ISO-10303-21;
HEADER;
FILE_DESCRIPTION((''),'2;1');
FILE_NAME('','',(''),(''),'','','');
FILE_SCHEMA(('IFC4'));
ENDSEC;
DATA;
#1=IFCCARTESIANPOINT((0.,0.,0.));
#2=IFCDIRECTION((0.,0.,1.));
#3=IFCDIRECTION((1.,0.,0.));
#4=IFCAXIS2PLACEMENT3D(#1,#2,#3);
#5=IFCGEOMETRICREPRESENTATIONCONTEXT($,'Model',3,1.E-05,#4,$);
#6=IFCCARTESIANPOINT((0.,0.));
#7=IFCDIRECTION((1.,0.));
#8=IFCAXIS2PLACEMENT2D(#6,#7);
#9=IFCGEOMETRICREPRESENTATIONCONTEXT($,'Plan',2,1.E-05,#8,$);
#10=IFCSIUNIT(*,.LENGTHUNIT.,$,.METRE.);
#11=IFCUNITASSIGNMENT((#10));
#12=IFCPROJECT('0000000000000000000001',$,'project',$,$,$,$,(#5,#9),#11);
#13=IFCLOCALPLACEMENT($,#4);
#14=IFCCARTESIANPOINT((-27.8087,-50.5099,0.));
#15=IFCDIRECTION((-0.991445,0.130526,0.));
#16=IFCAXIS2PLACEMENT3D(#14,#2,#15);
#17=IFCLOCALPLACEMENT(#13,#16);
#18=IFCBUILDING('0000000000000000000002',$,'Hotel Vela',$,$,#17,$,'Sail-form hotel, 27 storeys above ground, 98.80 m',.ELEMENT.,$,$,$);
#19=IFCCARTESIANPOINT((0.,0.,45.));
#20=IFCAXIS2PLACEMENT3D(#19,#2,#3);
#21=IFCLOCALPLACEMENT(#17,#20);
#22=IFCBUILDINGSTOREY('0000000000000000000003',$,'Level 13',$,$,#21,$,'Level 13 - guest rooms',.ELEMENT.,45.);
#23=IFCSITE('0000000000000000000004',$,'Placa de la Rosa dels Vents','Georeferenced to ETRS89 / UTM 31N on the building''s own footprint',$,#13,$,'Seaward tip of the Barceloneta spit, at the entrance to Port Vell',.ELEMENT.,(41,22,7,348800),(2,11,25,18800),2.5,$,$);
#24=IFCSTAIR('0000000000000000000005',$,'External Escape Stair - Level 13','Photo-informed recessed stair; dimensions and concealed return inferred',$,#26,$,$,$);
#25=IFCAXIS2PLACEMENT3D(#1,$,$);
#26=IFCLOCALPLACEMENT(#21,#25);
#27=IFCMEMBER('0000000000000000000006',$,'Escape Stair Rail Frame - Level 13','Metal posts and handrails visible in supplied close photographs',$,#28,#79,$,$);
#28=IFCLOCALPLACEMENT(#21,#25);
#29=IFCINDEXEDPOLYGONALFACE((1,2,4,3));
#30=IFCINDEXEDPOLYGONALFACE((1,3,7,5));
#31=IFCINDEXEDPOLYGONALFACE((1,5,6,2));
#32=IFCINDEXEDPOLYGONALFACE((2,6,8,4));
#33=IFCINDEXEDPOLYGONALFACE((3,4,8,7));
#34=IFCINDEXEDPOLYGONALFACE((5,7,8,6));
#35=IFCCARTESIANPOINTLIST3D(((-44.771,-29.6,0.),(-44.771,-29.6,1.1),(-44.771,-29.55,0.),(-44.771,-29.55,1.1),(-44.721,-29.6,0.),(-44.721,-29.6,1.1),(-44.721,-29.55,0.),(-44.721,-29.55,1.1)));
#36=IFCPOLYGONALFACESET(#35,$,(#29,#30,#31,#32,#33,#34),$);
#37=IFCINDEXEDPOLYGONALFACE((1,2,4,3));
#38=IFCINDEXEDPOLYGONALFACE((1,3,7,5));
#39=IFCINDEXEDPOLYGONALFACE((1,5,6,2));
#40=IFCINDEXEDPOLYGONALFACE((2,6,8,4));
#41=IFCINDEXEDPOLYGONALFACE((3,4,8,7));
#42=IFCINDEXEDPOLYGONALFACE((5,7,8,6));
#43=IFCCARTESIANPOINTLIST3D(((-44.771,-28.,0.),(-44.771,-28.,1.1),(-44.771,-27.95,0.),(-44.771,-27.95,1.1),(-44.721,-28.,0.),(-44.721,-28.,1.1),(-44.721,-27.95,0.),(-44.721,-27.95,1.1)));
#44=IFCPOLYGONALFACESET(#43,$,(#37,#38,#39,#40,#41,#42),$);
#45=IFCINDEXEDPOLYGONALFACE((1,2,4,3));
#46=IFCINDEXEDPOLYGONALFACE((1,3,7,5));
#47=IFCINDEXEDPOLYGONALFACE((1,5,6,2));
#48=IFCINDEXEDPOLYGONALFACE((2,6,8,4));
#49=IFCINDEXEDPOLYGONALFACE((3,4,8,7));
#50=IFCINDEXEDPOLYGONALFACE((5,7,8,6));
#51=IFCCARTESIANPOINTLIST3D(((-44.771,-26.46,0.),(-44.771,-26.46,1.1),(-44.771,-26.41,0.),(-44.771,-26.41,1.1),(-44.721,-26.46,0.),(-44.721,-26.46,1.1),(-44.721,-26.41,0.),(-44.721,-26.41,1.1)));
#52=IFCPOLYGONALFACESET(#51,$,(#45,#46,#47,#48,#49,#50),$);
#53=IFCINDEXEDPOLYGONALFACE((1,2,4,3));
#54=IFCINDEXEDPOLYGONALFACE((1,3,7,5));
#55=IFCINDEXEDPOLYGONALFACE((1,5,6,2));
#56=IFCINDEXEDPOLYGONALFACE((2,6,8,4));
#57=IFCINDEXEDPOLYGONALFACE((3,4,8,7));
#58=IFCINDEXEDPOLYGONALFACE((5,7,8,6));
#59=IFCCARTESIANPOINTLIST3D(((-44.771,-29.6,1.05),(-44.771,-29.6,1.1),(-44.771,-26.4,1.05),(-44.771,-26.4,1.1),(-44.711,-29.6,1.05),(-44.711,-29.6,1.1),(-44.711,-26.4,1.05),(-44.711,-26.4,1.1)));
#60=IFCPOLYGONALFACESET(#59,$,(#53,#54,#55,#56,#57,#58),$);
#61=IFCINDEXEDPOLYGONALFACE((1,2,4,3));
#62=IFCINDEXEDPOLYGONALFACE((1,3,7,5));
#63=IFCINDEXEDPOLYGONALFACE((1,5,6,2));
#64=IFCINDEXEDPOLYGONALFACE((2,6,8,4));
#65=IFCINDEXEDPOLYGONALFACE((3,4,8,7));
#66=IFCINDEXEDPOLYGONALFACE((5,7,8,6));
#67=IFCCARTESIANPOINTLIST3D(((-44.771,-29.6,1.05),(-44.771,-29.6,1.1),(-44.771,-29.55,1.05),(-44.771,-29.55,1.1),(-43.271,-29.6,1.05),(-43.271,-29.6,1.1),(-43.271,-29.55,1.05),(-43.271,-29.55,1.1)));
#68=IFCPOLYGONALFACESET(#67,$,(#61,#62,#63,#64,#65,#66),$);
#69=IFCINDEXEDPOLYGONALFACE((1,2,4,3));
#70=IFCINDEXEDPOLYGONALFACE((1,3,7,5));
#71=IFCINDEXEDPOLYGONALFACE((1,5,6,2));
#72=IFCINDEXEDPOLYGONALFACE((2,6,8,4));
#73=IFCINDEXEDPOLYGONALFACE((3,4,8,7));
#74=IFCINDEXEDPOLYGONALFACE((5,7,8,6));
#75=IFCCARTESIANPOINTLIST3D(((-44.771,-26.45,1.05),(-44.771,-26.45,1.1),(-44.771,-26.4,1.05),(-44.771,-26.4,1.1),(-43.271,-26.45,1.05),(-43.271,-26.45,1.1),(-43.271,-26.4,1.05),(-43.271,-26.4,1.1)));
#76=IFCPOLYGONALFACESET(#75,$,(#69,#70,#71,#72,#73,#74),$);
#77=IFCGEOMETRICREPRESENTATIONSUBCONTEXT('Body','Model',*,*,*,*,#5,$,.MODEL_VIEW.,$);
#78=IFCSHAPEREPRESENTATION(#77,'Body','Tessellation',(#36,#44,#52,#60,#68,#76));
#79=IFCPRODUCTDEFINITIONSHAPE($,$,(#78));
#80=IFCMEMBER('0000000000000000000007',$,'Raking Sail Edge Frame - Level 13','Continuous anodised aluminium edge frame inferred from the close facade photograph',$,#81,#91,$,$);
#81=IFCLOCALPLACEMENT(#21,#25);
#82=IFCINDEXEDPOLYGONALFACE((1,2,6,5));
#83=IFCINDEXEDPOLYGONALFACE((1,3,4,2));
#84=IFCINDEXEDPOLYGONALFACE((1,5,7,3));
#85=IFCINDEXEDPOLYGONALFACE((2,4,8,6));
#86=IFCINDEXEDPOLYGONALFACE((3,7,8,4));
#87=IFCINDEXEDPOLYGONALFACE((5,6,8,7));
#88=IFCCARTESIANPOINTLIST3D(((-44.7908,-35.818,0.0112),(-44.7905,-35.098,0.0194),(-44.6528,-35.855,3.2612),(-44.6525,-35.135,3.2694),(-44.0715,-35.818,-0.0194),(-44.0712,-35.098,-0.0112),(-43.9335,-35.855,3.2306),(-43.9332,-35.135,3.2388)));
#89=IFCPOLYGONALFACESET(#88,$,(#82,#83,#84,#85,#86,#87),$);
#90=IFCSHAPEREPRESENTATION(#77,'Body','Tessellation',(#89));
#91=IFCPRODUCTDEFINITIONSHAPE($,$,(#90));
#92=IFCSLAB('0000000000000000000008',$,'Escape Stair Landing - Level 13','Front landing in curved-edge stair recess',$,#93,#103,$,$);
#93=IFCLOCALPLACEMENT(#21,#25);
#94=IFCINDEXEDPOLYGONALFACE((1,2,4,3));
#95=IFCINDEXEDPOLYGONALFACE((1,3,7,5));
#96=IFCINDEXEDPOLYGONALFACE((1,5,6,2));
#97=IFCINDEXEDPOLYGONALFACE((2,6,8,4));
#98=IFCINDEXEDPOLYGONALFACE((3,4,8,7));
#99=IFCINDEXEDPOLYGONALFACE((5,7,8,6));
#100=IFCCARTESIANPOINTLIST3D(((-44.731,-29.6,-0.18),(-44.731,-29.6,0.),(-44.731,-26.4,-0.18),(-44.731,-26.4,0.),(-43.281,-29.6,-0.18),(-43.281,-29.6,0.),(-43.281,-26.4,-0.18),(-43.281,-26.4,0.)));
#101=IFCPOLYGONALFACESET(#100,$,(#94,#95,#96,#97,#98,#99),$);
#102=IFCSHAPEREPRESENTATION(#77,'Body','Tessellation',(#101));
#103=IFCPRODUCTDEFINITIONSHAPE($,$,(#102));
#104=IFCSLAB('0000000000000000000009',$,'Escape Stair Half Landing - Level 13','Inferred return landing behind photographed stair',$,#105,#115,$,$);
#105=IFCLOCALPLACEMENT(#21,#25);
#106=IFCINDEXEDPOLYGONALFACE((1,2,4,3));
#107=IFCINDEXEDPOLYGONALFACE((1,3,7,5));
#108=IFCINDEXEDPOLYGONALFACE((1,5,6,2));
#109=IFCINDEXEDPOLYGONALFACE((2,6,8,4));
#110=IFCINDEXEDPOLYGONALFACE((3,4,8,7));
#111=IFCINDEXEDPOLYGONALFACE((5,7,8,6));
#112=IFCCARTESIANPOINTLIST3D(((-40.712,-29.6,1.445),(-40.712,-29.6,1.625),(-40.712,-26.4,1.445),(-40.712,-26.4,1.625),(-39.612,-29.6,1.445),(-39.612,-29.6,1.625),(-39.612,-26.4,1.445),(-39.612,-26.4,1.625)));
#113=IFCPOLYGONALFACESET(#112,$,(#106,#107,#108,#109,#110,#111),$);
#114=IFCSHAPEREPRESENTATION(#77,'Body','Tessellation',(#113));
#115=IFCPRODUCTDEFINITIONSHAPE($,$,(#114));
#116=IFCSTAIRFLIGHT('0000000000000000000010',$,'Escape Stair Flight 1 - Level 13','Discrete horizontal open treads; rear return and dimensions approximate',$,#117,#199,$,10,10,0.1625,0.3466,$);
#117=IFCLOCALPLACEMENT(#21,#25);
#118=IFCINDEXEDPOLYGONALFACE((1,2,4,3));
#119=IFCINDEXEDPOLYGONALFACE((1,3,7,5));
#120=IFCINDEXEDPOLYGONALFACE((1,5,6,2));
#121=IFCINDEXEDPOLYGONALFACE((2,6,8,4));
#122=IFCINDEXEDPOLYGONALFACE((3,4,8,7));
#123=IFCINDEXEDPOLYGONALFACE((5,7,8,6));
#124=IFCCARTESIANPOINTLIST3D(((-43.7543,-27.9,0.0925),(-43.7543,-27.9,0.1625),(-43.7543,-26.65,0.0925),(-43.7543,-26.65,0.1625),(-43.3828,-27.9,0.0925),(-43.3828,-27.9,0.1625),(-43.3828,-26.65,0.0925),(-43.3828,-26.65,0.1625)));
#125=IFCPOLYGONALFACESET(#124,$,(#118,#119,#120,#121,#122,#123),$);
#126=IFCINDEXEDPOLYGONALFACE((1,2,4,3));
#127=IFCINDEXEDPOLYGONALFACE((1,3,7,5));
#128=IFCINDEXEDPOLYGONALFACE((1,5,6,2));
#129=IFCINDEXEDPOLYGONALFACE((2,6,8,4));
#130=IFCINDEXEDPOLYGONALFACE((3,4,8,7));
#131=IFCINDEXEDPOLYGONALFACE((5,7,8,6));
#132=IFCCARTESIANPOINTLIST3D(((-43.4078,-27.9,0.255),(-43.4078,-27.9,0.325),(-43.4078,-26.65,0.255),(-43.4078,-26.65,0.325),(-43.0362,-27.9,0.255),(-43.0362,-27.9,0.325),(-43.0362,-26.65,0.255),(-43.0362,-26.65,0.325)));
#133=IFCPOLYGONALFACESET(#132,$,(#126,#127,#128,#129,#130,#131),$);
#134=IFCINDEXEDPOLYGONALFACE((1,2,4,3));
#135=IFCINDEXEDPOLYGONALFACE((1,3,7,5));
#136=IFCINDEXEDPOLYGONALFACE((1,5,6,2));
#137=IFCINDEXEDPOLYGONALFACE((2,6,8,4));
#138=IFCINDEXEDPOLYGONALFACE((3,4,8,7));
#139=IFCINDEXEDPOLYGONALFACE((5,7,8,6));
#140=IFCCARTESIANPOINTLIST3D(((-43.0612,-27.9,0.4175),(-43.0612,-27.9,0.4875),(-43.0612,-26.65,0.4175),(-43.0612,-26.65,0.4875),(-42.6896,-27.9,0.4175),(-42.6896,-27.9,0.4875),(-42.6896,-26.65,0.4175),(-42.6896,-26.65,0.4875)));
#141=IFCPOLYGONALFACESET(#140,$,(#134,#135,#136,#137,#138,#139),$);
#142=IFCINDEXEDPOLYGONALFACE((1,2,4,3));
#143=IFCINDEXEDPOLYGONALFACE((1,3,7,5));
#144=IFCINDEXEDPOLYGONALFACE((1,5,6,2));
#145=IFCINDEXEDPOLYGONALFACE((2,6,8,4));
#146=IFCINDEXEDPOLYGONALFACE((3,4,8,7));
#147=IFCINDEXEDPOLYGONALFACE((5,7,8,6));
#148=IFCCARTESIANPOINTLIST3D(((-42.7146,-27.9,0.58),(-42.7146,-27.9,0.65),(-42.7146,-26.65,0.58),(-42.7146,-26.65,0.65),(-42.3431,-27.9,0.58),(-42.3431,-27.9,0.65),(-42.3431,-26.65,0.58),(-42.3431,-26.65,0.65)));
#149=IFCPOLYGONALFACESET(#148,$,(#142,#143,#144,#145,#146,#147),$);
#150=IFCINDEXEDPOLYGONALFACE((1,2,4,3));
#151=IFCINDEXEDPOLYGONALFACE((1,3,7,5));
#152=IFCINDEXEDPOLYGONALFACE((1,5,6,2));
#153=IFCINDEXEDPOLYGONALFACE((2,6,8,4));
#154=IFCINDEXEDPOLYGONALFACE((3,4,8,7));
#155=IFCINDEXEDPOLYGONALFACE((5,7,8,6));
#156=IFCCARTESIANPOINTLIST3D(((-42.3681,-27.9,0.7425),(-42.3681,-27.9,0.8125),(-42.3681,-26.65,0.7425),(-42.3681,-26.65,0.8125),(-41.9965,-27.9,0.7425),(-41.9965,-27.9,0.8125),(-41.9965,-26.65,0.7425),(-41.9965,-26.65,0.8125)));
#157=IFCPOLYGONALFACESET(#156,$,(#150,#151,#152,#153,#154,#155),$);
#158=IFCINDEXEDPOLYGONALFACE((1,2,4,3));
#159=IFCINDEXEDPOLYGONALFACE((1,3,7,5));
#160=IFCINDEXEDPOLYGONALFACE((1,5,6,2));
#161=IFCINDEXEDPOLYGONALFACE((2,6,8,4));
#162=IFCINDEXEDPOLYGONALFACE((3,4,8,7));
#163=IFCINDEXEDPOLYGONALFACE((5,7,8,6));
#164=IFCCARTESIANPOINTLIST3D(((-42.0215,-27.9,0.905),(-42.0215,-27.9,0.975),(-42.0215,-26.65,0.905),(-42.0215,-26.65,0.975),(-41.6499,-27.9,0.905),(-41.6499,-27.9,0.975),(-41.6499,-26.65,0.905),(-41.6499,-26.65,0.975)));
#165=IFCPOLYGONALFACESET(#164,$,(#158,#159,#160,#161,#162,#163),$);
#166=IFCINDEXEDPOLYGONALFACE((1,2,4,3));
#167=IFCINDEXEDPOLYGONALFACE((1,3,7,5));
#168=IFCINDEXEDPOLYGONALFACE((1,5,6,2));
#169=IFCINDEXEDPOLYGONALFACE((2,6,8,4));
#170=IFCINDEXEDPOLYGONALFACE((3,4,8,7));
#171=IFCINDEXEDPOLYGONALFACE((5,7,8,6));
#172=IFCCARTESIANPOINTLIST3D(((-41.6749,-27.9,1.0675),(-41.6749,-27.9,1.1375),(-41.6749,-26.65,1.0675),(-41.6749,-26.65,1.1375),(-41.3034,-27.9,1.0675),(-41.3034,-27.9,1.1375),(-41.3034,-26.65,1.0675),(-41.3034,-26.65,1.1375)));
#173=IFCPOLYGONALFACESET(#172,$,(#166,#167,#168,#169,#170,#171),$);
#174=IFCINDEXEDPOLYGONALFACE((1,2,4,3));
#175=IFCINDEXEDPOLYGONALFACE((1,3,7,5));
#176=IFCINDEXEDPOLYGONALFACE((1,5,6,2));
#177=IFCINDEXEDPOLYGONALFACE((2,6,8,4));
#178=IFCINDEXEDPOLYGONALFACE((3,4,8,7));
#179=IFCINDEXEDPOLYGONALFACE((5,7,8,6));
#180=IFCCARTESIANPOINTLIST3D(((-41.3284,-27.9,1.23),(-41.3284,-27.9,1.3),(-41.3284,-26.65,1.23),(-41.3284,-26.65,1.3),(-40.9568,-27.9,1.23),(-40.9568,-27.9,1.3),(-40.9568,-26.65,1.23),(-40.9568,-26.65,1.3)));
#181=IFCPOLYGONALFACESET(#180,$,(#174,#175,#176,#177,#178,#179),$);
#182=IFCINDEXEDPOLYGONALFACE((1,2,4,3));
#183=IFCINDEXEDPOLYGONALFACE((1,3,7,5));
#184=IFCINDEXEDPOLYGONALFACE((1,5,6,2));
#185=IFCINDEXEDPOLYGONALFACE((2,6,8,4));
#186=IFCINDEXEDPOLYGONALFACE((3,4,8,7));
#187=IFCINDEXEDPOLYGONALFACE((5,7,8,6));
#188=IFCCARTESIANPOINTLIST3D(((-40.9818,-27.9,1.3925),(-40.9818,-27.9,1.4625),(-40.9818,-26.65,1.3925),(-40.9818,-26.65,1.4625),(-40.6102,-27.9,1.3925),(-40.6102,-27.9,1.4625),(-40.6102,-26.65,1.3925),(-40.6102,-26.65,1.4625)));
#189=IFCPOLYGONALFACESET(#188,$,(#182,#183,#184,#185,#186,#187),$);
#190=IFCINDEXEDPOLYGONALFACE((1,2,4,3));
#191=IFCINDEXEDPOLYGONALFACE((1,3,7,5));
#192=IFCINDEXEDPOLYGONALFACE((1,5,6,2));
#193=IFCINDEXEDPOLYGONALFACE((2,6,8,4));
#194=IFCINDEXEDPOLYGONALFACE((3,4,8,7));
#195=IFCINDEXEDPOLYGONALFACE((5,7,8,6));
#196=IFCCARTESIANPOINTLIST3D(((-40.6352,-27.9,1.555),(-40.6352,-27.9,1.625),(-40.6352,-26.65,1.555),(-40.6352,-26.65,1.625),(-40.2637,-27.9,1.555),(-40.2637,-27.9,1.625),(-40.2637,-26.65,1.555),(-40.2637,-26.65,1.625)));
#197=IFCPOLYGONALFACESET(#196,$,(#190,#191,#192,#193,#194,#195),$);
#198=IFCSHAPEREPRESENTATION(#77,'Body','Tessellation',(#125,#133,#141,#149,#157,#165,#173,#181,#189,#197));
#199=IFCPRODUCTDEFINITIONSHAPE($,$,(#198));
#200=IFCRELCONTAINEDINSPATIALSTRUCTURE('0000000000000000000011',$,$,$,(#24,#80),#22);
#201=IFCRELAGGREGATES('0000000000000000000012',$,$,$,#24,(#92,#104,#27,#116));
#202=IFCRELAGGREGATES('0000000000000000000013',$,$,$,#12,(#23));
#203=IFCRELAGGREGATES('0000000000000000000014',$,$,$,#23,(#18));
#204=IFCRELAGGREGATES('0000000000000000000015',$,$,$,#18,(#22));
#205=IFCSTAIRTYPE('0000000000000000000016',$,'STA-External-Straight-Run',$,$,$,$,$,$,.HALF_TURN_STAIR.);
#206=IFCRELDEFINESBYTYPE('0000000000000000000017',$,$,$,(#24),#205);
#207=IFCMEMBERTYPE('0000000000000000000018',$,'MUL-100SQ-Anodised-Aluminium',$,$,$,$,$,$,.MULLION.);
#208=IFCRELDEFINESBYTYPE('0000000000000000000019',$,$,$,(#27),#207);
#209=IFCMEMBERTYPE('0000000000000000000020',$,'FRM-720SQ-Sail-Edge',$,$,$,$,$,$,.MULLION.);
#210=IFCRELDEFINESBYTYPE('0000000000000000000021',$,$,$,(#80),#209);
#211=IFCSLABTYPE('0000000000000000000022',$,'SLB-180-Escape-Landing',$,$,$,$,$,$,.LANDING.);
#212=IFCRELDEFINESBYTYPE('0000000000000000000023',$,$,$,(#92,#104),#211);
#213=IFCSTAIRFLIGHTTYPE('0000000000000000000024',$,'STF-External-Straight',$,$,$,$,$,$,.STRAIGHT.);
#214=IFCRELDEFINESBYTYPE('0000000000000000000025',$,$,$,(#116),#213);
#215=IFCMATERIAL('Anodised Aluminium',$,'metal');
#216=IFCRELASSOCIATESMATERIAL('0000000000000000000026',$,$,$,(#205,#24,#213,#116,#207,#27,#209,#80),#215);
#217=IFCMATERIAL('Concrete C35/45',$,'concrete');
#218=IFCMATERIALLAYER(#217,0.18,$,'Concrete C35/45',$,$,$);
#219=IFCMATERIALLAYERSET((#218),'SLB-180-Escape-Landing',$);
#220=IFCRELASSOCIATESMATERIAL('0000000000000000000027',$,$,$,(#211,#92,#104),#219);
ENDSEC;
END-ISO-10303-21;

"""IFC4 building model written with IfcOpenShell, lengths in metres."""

from ifc_helpers import new_model, si_unit, frame, origin_with_axes, origin_2d_with_axis, place, context, subcontext, project, spatial, line, indexed_curve, rectangle, outline, extrude, material, layer, layer_set, layer_usage, material_profile, profile_set, profile_usage, type_object, element, aggregate, save


model = new_model("IFC4")

# Units and contexts
model_context = context("Model", 3, precision=1e-05, world=origin_with_axes())
plan_context = context("Plan", 2, precision=1e-05, world=origin_2d_with_axis())
body_context = subcontext(model_context, "Body", "Model", "MODEL_VIEW")
ifc_project = project(units=[si_unit("LENGTHUNIT", "METRE")], contexts=[model_context, plan_context])

# Site, building, storey
site_placement = place(None, origin_with_axes())
site = spatial("IfcSite", under=ifc_project, at=site_placement, Name="Placa de la Rosa dels Vents", Description="Georeferenced to ETRS89 / UTM 31N on the building's own footprint", LongName="Seaward tip of the Barceloneta spit, at the entrance to Port Vell", CompositionType="ELEMENT", RefLatitude=(41, 22, 7, 348800), RefLongitude=(2, 11, 25, 18800), RefElevation=2.5)
building_placement = place(site_placement, frame((-27.8087, -50.5099, 0.0), z_axis=(0.0, 0.0, 1.0), x_axis=(-0.991445, 0.130526, 0.0)))
building = spatial("IfcBuilding", under=site, at=building_placement, Name="Hotel Vela", LongName="Sail-form hotel, 27 storeys above ground, 98.80 m", CompositionType="ELEMENT")
storey_placement = place(building_placement, frame((0.0, 0.0, 45.0), z_axis=(0.0, 0.0, 1.0), x_axis=(1.0, 0.0, 0.0)))
storey = spatial("IfcBuildingStorey", under=building, at=storey_placement, Name="Level 13", LongName="Level 13 - guest rooms", CompositionType="ELEMENT", Elevation=45.0)

# Stair, member
ifc_material_1 = material(Name="Anodised Aluminium", Category="metal")
stair_type = type_object("IfcStairType", Name="STA-External-Straight-Run", PredefinedType="HALF_TURN_STAIR", material=ifc_material_1)
stair_placement = place(storey_placement, frame((0.0, 0.0, -45.0), z_axis=(0.0, 0.0, 1.0), x_axis=(1.0, 0.0, 0.0)))
stair = element("IfcStair", 1, at=stair_placement, inside=storey, type_object=stair_type, material=ifc_material_1, Name="External Escape Stair - Level 13", Description="Photo-informed recessed stair; dimensions and concealed return inferred")
ifc_material_profile_1 = material_profile(ifc_material_1, rectangle(XDim=0.1, YDim=0.1))
ifc_profile_set_1 = profile_set([ifc_material_profile_1], Name="MUL-100SQ-Anodised-Aluminium")
ifc_profile_usage_1 = profile_usage(ifc_profile_set_1)
member_type_1 = type_object("IfcMemberType", Name="MUL-100SQ-Anodised-Aluminium", PredefinedType="MULLION", material=ifc_profile_set_1)
member_1_placement = place(stair_placement, origin_with_axes())
member_1 = element("IfcMember", 2, at=member_1_placement, type_object=member_type_1, material=ifc_profile_usage_1, Name="Escape Stair Rail Frame - Level 13", Description="Metal posts and handrails visible in supplied close photographs", context=body_context, shape_type="SweptSolid", body=[
    extrude(outline(indexed_curve([(0.0, 0.0), (0.05, 0.0), (0.05, 0.05), (0.0, 0.05)], segments=[line(1, 2, 3, 4, 1)])), frame((-44.771, -29.6, 45.0), z_axis=(0.0, 0.0, 1.0), x_axis=(1.0, 0.0, 0.0)), (0.0, 0.0, 1.0), 1.1),
    extrude(outline(indexed_curve([(0.0, 0.0), (0.05, 0.0), (0.05, 0.05), (0.0, 0.05)], segments=[line(1, 2, 3, 4, 1)])), frame((-44.771, -28.0, 45.0), z_axis=(0.0, 0.0, 1.0), x_axis=(1.0, 0.0, 0.0)), (0.0, 0.0, 1.0), 1.1),
    extrude(outline(indexed_curve([(0.0, 0.0), (0.05, 0.0), (0.05, 0.05), (0.0, 0.05)], segments=[line(1, 2, 3, 4, 1)])), frame((-44.771, -26.46, 45.0), z_axis=(0.0, 0.0, 1.0), x_axis=(1.0, 0.0, 0.0)), (0.0, 0.0, 1.0), 1.1),
    extrude(outline(indexed_curve([(0.0, 0.0), (0.06, 0.0), (0.06, 3.2), (0.0, 3.2)], segments=[line(1, 2, 3, 4, 1)])), frame((-44.771, -29.6, 46.05), z_axis=(0.0, 0.0, 1.0), x_axis=(1.0, 0.0, 0.0)), (0.0, 0.0, 1.0), 0.05),
    extrude(outline(indexed_curve([(0.0, 0.0), (1.5, 0.0), (1.5, 0.05), (0.0, 0.05)], segments=[line(1, 2, 3, 4, 1)])), frame((-44.771, -29.6, 46.05), z_axis=(0.0, 0.0, 1.0), x_axis=(1.0, 0.0, 0.0)), (0.0, 0.0, 1.0), 0.05),
    extrude(outline(indexed_curve([(0.0, 0.0), (1.5, 0.0), (1.5, 0.05), (0.0, 0.05)], segments=[line(1, 2, 3, 4, 1)])), frame((-44.771, -26.45, 46.05), z_axis=(0.0, 0.0, 1.0), x_axis=(1.0, 0.0, 0.0)), (0.0, 0.0, 1.0), 0.05),
])

# Member
ifc_material_profile_2 = material_profile(ifc_material_1, rectangle(XDim=0.72, YDim=0.72))
ifc_profile_set_2 = profile_set([ifc_material_profile_2], Name="FRM-720SQ-Sail-Edge")
ifc_profile_usage_2 = profile_usage(ifc_profile_set_2)
member_type_2 = type_object("IfcMemberType", Name="FRM-720SQ-Sail-Edge", PredefinedType="MULLION", material=ifc_profile_set_2)
member_2_placement = place(storey_placement, frame((-44.431, -35.458, 0.0), z_axis=(0.042421, -0.011374, 0.999035), x_axis=(0.9991, 0.0, -0.042423)))
element("IfcMember", 3, at=member_2_placement, inside=storey, type_object=member_type_2, material=ifc_profile_usage_2, Name="Raking Sail Edge Frame - Level 13", Description="Continuous anodised aluminium edge frame inferred from the close facade photograph", context=body_context, shape_type="SweptSolid", body=[
    extrude(outline(indexed_curve([(-0.36, -0.36), (0.36, -0.36), (0.36, 0.36), (-0.36, 0.36)], segments=[line(1, 2, 3, 4, 1)])), origin_with_axes(), (0.0, 0.0, 1.0), 3.2531),
])

# Slabs
ifc_material_2 = material(Name="Concrete C35/45", Category="concrete")
ifc_layer = layer(ifc_material_2, 0.18, Name="Concrete C35/45")
ifc_layer_set = layer_set([ifc_layer], Name="SLB-180-Escape-Landing")
ifc_layer_usage_1 = layer_usage(ifc_layer_set, "AXIS3", "POSITIVE", 0.0)
slab_type = type_object("IfcSlabType", Name="SLB-180-Escape-Landing", PredefinedType="LANDING", material=ifc_layer_set)
slab_1_placement = place(stair_placement, frame((-44.731, -29.6, 44.82), z_axis=(0.0, 0.0, 1.0), x_axis=(1.0, 0.0, 0.0)))
slab_1 = element("IfcSlab", 4, at=slab_1_placement, type_object=slab_type, material=ifc_layer_usage_1, Name="Escape Stair Landing - Level 13", Description="Front landing in curved-edge stair recess", context=body_context, shape_type="SweptSolid", body=[
    extrude(outline(indexed_curve([(0.0, 0.0), (1.45, 0.0), (1.45, 3.2), (0.0, 3.2)], segments=[line(1, 2, 3, 4, 1)])), origin_with_axes(), (0.0, 0.0, 1.0), 0.18),
])
ifc_layer_usage_2 = layer_usage(ifc_layer_set, "AXIS3", "POSITIVE", 0.0)
slab_2_placement = place(stair_placement, frame((-40.712, -29.6, 46.445), z_axis=(0.0, 0.0, 1.0), x_axis=(1.0, 0.0, 0.0)))
slab_2 = element("IfcSlab", 5, at=slab_2_placement, type_object=slab_type, material=ifc_layer_usage_2, Name="Escape Stair Half Landing - Level 13", Description="Inferred return landing behind photographed stair", context=body_context, shape_type="SweptSolid", body=[
    extrude(outline(indexed_curve([(0.0, 0.0), (1.1, 0.0), (1.1, 3.2), (0.0, 3.2)], segments=[line(1, 2, 3, 4, 1)])), origin_with_axes(), (0.0, 0.0, 1.0), 0.18),
])

# Stair flight
stair_flight_type = type_object("IfcStairFlightType", Name="STF-External-Straight", PredefinedType="STRAIGHT", material=ifc_material_1)
stair_flight_1_placement = place(stair_placement, origin_with_axes())
stair_flight_1 = element("IfcStairFlight", 6, at=stair_flight_1_placement, type_object=stair_flight_type, material=ifc_material_1, Name="Escape Stair Flight 1 - Level 13", Description="Discrete horizontal open treads; rear return and dimensions approximate", NumberOfRisers=10, NumberOfTreads=10, RiserHeight=0.1625, TreadLength=0.3466, context=body_context, shape_type="SweptSolid", body=[
    extrude(outline(indexed_curve([(0.0, 0.0), (0.3716, 0.0), (0.3716, 1.25), (0.0, 1.25)], segments=[line(1, 2, 3, 4, 1)])), frame((-43.7543, -27.9, 45.0925), z_axis=(0.0, 0.0, 1.0), x_axis=(1.0, 0.0, 0.0)), (0.0, 0.0, 1.0), 0.07),
    extrude(outline(indexed_curve([(0.0, 0.0), (0.3716, 0.0), (0.3716, 1.25), (0.0, 1.25)], segments=[line(1, 2, 3, 4, 1)])), frame((-43.4078, -27.9, 45.255), z_axis=(0.0, 0.0, 1.0), x_axis=(1.0, 0.0, 0.0)), (0.0, 0.0, 1.0), 0.07),
    extrude(outline(indexed_curve([(0.0, 0.0), (0.3716, 0.0), (0.3716, 1.25), (0.0, 1.25)], segments=[line(1, 2, 3, 4, 1)])), frame((-43.0612, -27.9, 45.4175), z_axis=(0.0, 0.0, 1.0), x_axis=(1.0, 0.0, 0.0)), (0.0, 0.0, 1.0), 0.07),
    extrude(outline(indexed_curve([(0.0, 0.0), (0.3716, 0.0), (0.3716, 1.25), (0.0, 1.25)], segments=[line(1, 2, 3, 4, 1)])), frame((-42.7146, -27.9, 45.58), z_axis=(0.0, 0.0, 1.0), x_axis=(1.0, 0.0, 0.0)), (0.0, 0.0, 1.0), 0.07),
    extrude(outline(indexed_curve([(0.0, 0.0), (0.3716, 0.0), (0.3716, 1.25), (0.0, 1.25)], segments=[line(1, 2, 3, 4, 1)])), frame((-42.3681, -27.9, 45.7425), z_axis=(0.0, 0.0, 1.0), x_axis=(1.0, 0.0, 0.0)), (0.0, 0.0, 1.0), 0.07),
    extrude(outline(indexed_curve([(0.0, 0.0), (0.3716, 0.0), (0.3716, 1.25), (0.0, 1.25)], segments=[line(1, 2, 3, 4, 1)])), frame((-42.0215, -27.9, 45.905), z_axis=(0.0, 0.0, 1.0), x_axis=(1.0, 0.0, 0.0)), (0.0, 0.0, 1.0), 0.07),
    extrude(outline(indexed_curve([(0.0, 0.0), (0.3716, 0.0), (0.3716, 1.25), (0.0, 1.25)], segments=[line(1, 2, 3, 4, 1)])), frame((-41.6749, -27.9, 46.0675), z_axis=(0.0, 0.0, 1.0), x_axis=(1.0, 0.0, 0.0)), (0.0, 0.0, 1.0), 0.07),
    extrude(outline(indexed_curve([(0.0, 0.0), (0.3716, 0.0), (0.3716, 1.25), (0.0, 1.25)], segments=[line(1, 2, 3, 4, 1)])), frame((-41.3284, -27.9, 46.23), z_axis=(0.0, 0.0, 1.0), x_axis=(1.0, 0.0, 0.0)), (0.0, 0.0, 1.0), 0.07),
    extrude(outline(indexed_curve([(0.0, 0.0), (0.3716, 0.0), (0.3716, 1.25), (0.0, 1.25)], segments=[line(1, 2, 3, 4, 1)])), frame((-40.9818, -27.9, 46.3925), z_axis=(0.0, 0.0, 1.0), x_axis=(1.0, 0.0, 0.0)), (0.0, 0.0, 1.0), 0.07),
    extrude(outline(indexed_curve([(0.0, 0.0), (0.3716, 0.0), (0.3716, 1.25), (0.0, 1.25)], segments=[line(1, 2, 3, 4, 1)])), frame((-40.6352, -27.9, 46.555), z_axis=(0.0, 0.0, 1.0), x_axis=(1.0, 0.0, 0.0)), (0.0, 0.0, 1.0), 0.07),
])

aggregate(stair, [slab_1, slab_2, member_1, stair_flight_1])

save(model, "model.ifc")
